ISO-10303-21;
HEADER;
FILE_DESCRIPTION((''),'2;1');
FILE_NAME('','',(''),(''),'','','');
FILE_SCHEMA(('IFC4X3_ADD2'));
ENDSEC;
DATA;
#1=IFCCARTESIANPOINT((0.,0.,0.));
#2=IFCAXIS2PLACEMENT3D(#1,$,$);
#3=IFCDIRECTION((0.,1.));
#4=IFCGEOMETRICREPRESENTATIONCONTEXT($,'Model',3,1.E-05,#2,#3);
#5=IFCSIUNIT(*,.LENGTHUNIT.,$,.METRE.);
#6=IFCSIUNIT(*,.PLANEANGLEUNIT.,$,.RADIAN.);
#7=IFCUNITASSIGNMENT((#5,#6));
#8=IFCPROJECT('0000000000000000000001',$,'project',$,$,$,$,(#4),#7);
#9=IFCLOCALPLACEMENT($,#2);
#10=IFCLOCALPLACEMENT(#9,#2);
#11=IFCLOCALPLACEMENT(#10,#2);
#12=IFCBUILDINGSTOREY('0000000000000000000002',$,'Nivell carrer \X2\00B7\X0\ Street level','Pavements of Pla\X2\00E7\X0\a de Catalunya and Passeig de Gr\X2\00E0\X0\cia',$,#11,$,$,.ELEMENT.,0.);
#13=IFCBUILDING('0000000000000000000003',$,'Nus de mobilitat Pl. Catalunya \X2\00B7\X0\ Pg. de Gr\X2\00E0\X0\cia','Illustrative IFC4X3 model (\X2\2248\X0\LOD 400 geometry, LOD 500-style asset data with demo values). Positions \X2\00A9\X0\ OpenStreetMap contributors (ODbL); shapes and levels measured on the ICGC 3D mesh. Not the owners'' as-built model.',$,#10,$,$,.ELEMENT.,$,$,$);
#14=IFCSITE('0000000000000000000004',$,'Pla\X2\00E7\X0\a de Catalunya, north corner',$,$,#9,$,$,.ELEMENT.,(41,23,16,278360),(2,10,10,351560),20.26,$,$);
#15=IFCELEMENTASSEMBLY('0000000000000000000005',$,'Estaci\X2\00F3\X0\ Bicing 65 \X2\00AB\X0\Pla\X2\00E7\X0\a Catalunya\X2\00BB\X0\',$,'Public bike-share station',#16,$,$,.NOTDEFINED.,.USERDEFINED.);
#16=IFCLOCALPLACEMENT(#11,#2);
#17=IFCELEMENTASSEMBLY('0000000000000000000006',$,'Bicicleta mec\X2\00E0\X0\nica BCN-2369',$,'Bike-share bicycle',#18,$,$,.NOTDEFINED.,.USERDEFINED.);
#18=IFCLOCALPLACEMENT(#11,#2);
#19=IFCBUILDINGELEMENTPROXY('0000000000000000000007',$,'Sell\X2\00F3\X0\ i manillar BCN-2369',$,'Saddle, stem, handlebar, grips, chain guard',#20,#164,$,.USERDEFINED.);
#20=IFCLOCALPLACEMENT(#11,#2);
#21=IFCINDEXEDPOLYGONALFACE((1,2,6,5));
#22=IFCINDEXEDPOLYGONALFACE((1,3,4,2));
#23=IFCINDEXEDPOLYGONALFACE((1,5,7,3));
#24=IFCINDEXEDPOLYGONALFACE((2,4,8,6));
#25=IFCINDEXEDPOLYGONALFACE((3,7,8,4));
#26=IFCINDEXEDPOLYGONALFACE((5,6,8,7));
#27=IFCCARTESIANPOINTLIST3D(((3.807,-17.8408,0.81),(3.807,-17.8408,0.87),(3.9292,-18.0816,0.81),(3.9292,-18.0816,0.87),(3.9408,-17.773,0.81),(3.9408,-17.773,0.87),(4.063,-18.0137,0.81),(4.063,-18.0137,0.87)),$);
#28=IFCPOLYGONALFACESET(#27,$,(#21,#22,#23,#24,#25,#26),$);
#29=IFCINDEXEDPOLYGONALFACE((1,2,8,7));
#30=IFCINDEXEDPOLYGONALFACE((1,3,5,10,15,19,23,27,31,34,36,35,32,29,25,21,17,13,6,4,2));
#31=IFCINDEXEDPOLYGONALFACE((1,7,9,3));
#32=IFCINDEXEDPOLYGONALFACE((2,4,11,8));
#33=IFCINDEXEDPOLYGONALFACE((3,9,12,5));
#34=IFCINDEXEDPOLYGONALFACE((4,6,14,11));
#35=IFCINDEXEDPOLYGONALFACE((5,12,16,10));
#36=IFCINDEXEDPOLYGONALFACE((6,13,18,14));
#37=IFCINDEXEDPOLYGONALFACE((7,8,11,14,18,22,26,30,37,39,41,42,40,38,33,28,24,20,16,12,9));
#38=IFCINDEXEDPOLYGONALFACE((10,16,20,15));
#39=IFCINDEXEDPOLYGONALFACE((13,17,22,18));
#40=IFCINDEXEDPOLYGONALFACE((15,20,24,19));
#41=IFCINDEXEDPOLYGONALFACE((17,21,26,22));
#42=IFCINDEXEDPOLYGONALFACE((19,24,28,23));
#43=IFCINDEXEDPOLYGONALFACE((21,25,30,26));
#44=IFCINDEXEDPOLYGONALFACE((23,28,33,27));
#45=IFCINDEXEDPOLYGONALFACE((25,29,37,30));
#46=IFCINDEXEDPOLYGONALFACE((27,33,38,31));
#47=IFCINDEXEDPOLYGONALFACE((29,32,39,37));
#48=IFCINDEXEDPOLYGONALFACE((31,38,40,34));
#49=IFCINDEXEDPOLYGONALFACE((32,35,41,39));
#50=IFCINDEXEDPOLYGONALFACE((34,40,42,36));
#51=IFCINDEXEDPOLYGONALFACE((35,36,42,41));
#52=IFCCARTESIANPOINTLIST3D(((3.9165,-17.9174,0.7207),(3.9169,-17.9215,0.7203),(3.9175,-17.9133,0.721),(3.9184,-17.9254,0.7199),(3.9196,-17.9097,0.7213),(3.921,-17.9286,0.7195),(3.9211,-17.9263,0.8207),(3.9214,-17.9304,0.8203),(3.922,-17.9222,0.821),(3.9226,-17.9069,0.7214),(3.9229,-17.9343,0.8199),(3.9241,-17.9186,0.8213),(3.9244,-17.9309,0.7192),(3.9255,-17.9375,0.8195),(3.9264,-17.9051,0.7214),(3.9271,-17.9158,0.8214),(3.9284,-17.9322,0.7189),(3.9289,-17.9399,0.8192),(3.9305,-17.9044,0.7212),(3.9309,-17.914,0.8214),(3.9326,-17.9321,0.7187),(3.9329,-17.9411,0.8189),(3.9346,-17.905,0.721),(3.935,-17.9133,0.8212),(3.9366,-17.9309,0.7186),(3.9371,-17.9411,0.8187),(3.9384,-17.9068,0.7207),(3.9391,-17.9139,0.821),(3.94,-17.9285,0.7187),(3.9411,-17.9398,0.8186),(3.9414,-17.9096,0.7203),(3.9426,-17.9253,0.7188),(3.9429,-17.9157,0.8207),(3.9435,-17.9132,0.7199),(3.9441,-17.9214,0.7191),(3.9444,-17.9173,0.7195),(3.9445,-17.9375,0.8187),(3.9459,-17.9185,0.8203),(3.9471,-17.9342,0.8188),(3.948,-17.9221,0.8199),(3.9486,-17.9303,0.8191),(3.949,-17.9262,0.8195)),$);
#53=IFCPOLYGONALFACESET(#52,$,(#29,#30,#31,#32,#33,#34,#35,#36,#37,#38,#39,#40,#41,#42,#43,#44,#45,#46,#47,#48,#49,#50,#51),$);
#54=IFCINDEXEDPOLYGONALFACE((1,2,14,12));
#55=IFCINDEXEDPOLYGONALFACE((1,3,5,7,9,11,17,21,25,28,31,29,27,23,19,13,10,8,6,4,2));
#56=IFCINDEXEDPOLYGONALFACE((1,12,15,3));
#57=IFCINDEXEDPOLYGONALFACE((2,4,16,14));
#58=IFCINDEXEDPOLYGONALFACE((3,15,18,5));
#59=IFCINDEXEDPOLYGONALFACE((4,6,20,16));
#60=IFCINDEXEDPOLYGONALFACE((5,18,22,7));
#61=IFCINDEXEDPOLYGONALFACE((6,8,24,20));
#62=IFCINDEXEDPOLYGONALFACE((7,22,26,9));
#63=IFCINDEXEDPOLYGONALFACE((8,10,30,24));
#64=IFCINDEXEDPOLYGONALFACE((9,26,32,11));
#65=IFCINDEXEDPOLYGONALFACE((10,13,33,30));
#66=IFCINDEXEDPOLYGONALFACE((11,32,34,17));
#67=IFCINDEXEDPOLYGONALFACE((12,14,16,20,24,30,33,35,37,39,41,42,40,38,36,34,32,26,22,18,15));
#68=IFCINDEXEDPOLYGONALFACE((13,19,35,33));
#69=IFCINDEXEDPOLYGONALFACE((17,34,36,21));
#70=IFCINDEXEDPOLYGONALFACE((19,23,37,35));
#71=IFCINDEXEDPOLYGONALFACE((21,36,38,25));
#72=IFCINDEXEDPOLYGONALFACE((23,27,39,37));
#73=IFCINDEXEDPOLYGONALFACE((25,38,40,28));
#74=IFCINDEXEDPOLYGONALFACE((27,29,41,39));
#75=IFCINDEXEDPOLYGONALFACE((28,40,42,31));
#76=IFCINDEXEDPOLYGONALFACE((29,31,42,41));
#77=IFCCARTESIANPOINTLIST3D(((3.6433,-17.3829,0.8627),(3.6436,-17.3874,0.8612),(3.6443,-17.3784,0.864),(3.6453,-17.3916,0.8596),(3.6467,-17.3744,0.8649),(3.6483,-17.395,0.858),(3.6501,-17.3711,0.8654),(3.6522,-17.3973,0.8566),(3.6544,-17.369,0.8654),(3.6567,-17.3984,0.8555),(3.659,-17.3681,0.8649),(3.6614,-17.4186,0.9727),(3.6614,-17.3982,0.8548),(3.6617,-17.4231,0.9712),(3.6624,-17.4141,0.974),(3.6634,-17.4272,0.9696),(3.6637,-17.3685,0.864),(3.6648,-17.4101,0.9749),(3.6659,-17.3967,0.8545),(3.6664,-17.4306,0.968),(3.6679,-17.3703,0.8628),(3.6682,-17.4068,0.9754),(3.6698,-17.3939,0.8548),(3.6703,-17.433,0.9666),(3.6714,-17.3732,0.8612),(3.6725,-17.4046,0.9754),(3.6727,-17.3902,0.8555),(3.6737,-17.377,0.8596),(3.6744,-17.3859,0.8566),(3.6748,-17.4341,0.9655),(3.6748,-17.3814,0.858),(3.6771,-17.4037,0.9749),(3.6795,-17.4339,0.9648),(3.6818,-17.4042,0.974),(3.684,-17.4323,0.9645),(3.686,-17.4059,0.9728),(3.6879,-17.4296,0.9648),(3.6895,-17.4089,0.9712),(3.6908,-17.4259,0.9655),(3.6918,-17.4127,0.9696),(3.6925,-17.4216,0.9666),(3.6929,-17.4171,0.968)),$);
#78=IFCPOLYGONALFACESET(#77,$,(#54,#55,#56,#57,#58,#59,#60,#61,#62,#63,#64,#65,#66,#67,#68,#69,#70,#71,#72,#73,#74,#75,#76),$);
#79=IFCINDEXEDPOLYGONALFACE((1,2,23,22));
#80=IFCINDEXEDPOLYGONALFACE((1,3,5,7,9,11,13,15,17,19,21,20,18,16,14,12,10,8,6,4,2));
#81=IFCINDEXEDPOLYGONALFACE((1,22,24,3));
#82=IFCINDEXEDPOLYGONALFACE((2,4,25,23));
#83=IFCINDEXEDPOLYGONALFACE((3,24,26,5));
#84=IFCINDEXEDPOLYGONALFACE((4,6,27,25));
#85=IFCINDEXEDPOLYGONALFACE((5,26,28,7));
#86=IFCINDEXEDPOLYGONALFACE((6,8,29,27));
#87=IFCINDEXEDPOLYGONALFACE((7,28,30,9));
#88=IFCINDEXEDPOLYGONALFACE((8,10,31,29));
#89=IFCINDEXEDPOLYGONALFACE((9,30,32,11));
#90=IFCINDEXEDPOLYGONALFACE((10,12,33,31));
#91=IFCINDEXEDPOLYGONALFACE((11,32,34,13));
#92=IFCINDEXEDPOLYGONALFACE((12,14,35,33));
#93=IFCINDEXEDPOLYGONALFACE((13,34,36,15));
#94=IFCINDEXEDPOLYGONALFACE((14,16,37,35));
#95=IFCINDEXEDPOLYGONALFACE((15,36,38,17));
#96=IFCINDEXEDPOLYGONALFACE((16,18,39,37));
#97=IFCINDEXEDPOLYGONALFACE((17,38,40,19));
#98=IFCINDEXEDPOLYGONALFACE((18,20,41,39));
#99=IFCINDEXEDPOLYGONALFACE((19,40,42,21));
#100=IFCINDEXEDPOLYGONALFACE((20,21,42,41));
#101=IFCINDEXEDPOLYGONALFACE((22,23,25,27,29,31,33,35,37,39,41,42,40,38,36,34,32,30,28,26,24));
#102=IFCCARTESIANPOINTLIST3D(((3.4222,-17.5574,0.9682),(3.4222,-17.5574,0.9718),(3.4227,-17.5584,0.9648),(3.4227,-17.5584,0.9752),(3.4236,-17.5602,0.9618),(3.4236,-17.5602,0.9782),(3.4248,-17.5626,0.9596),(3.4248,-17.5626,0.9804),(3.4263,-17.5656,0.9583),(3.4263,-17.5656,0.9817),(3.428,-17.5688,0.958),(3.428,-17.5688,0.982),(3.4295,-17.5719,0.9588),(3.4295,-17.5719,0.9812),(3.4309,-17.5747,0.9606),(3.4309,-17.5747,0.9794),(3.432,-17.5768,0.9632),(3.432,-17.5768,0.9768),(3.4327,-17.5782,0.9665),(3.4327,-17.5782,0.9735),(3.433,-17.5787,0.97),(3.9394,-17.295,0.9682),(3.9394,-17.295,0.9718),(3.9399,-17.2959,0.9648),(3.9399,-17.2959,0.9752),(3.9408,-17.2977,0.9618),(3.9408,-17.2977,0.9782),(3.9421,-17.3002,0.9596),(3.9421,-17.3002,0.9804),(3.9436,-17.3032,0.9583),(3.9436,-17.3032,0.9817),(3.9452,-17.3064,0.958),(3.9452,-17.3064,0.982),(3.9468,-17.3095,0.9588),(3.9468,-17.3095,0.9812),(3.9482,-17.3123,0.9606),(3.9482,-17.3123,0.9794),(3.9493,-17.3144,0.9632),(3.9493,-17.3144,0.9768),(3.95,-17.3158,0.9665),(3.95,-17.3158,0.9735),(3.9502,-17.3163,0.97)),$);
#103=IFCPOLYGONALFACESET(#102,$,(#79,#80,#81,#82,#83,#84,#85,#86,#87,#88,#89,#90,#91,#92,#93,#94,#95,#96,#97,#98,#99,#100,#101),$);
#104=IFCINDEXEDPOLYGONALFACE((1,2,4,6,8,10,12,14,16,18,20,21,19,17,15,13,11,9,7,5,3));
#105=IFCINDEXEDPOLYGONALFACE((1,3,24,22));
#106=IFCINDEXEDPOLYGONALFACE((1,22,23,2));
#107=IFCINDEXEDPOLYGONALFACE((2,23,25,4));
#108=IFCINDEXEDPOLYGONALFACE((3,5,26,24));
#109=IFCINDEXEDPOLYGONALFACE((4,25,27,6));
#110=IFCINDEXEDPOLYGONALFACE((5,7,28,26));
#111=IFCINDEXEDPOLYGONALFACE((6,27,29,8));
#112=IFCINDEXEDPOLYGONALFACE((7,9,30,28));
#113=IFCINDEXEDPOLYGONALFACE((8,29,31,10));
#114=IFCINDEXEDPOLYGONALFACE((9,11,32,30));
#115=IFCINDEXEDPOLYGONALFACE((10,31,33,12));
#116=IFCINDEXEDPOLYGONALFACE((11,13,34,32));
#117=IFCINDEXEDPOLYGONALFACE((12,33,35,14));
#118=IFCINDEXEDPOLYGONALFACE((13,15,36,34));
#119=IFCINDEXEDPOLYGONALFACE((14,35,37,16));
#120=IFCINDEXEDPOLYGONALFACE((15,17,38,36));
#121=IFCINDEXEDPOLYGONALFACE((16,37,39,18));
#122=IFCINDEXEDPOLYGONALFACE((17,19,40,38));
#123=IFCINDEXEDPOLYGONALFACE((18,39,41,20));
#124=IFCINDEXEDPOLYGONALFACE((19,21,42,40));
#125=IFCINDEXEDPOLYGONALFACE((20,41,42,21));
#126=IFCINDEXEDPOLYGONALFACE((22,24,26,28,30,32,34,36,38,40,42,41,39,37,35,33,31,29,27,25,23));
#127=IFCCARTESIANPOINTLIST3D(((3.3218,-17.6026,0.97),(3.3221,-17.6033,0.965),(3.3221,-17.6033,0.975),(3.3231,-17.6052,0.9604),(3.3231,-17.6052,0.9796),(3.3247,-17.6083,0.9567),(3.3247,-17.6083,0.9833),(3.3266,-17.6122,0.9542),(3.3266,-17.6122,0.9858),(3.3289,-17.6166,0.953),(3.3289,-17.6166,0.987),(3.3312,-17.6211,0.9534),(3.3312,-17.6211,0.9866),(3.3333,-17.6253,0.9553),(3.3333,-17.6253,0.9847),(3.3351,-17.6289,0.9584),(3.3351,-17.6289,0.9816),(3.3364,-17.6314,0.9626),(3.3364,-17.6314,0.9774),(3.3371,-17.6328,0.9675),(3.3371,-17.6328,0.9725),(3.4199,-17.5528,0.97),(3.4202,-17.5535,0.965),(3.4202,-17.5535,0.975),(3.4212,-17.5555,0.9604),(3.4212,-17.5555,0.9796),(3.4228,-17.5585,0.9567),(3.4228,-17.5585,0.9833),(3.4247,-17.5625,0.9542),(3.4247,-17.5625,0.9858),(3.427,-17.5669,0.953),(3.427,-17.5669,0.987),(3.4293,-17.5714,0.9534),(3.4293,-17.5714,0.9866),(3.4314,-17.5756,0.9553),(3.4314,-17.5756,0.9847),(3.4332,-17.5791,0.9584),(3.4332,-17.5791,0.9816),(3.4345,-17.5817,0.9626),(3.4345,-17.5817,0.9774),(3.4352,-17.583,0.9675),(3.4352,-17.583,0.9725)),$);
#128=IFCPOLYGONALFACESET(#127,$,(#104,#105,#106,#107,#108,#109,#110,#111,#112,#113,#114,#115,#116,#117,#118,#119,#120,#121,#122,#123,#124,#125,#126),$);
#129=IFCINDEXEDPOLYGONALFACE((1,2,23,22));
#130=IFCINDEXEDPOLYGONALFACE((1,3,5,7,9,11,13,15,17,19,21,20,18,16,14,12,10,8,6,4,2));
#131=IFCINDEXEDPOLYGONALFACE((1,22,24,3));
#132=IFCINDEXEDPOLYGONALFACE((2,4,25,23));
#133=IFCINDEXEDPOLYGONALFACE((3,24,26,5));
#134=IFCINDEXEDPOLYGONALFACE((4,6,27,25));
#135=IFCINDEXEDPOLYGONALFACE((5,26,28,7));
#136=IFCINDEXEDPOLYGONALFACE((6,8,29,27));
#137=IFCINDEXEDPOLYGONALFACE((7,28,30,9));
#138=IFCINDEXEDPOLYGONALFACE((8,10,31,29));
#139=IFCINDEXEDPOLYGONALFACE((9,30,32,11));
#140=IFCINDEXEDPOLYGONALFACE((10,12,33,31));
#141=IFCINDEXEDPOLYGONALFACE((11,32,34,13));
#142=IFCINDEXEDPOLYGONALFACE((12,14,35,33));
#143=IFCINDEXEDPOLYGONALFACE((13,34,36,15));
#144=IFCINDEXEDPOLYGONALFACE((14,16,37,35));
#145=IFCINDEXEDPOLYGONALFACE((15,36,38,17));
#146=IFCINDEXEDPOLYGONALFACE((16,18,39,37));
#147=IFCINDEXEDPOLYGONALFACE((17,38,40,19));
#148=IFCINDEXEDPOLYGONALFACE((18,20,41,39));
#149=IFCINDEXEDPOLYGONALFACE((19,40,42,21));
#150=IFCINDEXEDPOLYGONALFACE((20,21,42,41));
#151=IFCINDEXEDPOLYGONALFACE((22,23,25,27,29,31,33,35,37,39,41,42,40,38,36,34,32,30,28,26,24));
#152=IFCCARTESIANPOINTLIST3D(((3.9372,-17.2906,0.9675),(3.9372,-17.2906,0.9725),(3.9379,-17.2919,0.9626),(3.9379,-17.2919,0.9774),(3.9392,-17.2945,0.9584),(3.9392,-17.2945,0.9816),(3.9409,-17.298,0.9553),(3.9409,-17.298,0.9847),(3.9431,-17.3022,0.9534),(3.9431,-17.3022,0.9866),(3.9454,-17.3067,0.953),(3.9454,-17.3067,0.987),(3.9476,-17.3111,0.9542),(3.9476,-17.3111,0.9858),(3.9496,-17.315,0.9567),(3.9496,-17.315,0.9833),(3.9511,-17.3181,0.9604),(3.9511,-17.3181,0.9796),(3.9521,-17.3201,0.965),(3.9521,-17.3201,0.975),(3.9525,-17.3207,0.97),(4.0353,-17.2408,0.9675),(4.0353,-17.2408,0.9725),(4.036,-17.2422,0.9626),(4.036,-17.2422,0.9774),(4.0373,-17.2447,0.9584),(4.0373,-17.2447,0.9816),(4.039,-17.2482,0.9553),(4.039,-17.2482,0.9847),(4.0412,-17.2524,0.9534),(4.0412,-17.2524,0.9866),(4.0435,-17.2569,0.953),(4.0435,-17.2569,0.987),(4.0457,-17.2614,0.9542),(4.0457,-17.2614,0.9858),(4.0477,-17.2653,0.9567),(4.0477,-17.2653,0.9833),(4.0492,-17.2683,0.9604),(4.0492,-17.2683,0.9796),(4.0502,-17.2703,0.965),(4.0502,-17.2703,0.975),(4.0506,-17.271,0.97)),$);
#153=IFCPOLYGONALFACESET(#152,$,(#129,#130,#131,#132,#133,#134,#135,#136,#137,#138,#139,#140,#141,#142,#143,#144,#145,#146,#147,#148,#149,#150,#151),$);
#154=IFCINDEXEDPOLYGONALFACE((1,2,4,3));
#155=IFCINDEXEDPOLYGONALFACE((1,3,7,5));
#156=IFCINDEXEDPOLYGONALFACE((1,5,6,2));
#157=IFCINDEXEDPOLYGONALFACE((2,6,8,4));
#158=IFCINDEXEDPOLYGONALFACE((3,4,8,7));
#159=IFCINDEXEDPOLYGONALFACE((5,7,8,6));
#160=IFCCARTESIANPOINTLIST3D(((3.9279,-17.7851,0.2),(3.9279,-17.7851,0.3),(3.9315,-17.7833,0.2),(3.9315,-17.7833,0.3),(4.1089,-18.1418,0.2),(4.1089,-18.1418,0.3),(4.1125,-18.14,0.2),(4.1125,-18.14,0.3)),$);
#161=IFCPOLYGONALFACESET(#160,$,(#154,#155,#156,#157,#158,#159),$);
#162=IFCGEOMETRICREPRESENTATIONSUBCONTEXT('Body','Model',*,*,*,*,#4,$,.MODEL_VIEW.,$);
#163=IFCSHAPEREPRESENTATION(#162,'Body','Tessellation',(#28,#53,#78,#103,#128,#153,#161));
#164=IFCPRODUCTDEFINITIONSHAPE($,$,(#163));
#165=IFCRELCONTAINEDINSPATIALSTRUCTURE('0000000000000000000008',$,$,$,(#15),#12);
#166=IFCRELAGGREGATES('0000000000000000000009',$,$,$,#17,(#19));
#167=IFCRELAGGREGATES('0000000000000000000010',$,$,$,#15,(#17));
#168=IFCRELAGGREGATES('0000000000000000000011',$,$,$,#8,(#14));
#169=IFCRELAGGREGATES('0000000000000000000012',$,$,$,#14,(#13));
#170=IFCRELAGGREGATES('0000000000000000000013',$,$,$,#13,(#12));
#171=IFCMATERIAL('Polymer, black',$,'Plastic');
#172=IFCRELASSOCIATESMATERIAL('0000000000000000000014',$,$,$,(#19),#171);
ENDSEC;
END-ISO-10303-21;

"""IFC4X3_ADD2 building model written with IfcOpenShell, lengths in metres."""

from ifc_helpers import new_model, si_unit, direction, frame, origin, origin_2d_with_axis, place, context, subcontext, project, spatial, rectangle, circle, extrude, material, element, aggregate, save


model = new_model("IFC4X3_ADD2")

# Units and contexts
model_context = context("Model", 3, precision=1e-05, world=origin(), true_north=direction((0.0, 1.0)))
body_context = subcontext(model_context, "Body", "Model", "MODEL_VIEW")
ifc_project = project(units=[si_unit("LENGTHUNIT", "METRE"), si_unit("PLANEANGLEUNIT", "RADIAN")], contexts=[model_context])

# Site, building, storey
site_placement = place(None, origin())
site = spatial("IfcSite", under=ifc_project, at=site_placement, Name="Plaça de Catalunya, north corner", CompositionType="ELEMENT", RefLatitude=(41, 23, 16, 278360), RefLongitude=(2, 10, 10, 351560), RefElevation=20.26)
building_placement = place(site_placement, origin())
building = spatial("IfcBuilding", under=site, at=building_placement, Name="Nus de mobilitat Pl. Catalunya · Pg. de Gràcia", Description="Illustrative IFC4X3 model (≈LOD 400 geometry, LOD 500-style asset data with demo values). Positions © OpenStreetMap contributors (ODbL); shapes and levels measured on the ICGC 3D mesh. Not the owners' as-built model.", CompositionType="ELEMENT")
storey_placement = place(building_placement, origin())
storey = spatial("IfcBuildingStorey", under=building, at=storey_placement, Name="Nivell carrer · Street level", Description="Pavements of Plaça de Catalunya and Passeig de Gràcia", CompositionType="ELEMENT", Elevation=0.0)

# Element assemblies, building element proxy
assembly_1_placement = place(building_placement, origin())
assembly_1 = element("IfcElementAssembly", 1, at=assembly_1_placement, inside=storey, Name="Estació Bicing 65 «Plaça Catalunya»", ObjectType="Public bike-share station", AssemblyPlace="NOTDEFINED", PredefinedType="USERDEFINED")
assembly_2_placement = place(building_placement, origin())
assembly_2 = element("IfcElementAssembly", 2, at=assembly_2_placement, Name="Bicicleta mecànica BCN-2369", ObjectType="Bike-share bicycle", AssemblyPlace="NOTDEFINED", PredefinedType="USERDEFINED")
ifc_material_1 = material(Name="Polymer, black", Category="Plastic")
proxy_1_placement = place(building_placement, origin())
proxy_1 = element("IfcBuildingElementProxy", 3, at=proxy_1_placement, material=ifc_material_1, Name="Selló i manillar BCN-2369", ObjectType="Saddle, stem, handlebar, grips, chain guard", PredefinedType="USERDEFINED", context=body_context, shape_type="SweptSolid", body=[
    extrude(rectangle(XDim=0.27, YDim=0.15, at=origin_2d_with_axis()), frame((3.935, -17.9273, 0.87), z_axis=(0.0, 0.0, -1.0), x_axis=(-0.452435, 0.891798, 0.0)), (0.0, 0.0, 1.0), 0.06),
    extrude(circle(Radius=0.014, at=origin_2d_with_axis()), frame((3.9305, -17.9184, 0.72), z_axis=(0.045019, -0.088737, 0.995037), x_axis=(0.0, 0.996047, 0.088827)), (0.0, 0.0, 1.0), 0.1005),
    extrude(circle(Radius=0.016, at=origin_2d_with_axis()), frame((3.659, -17.3833, 0.86), z_axis=(0.154616, -0.304766, 0.939793), x_axis=(0.0, 0.951232, 0.308475)), (0.0, 0.0, 1.0), 0.117),
    extrude(circle(Radius=0.012, at=origin_2d_with_axis()), frame((3.4276, -17.568, 0.97), z_axis=(0.891798, 0.452435, 0.0), x_axis=(0.452435, -0.891798, 0.0)), (0.0, 0.0, 1.0), 0.58),
    extrude(circle(Radius=0.017, at=origin_2d_with_axis()), frame((3.4276, -17.568, 0.97), z_axis=(-0.891798, -0.452435, 0.0), x_axis=(-0.452435, 0.891798, 0.0)), (0.0, 0.0, 1.0), 0.11),
    extrude(circle(Radius=0.017, at=origin_2d_with_axis()), frame((3.9448, -17.3056, 0.97), z_axis=(0.891798, 0.452435, 0.0), x_axis=(0.452435, -0.891798, 0.0)), (0.0, 0.0, 1.0), 0.11),
    extrude(rectangle(XDim=0.4, YDim=0.1, at=origin_2d_with_axis()), frame((4.0184, -17.9635, 0.25), z_axis=(0.891798, 0.452435, 0.0), x_axis=(-0.452435, 0.891798, 0.0)), (0.0, 0.0, 1.0), 0.004),
])
aggregate(assembly_2, [proxy_1])
aggregate(assembly_1, [assembly_2])

save(model, "model.ifc")
